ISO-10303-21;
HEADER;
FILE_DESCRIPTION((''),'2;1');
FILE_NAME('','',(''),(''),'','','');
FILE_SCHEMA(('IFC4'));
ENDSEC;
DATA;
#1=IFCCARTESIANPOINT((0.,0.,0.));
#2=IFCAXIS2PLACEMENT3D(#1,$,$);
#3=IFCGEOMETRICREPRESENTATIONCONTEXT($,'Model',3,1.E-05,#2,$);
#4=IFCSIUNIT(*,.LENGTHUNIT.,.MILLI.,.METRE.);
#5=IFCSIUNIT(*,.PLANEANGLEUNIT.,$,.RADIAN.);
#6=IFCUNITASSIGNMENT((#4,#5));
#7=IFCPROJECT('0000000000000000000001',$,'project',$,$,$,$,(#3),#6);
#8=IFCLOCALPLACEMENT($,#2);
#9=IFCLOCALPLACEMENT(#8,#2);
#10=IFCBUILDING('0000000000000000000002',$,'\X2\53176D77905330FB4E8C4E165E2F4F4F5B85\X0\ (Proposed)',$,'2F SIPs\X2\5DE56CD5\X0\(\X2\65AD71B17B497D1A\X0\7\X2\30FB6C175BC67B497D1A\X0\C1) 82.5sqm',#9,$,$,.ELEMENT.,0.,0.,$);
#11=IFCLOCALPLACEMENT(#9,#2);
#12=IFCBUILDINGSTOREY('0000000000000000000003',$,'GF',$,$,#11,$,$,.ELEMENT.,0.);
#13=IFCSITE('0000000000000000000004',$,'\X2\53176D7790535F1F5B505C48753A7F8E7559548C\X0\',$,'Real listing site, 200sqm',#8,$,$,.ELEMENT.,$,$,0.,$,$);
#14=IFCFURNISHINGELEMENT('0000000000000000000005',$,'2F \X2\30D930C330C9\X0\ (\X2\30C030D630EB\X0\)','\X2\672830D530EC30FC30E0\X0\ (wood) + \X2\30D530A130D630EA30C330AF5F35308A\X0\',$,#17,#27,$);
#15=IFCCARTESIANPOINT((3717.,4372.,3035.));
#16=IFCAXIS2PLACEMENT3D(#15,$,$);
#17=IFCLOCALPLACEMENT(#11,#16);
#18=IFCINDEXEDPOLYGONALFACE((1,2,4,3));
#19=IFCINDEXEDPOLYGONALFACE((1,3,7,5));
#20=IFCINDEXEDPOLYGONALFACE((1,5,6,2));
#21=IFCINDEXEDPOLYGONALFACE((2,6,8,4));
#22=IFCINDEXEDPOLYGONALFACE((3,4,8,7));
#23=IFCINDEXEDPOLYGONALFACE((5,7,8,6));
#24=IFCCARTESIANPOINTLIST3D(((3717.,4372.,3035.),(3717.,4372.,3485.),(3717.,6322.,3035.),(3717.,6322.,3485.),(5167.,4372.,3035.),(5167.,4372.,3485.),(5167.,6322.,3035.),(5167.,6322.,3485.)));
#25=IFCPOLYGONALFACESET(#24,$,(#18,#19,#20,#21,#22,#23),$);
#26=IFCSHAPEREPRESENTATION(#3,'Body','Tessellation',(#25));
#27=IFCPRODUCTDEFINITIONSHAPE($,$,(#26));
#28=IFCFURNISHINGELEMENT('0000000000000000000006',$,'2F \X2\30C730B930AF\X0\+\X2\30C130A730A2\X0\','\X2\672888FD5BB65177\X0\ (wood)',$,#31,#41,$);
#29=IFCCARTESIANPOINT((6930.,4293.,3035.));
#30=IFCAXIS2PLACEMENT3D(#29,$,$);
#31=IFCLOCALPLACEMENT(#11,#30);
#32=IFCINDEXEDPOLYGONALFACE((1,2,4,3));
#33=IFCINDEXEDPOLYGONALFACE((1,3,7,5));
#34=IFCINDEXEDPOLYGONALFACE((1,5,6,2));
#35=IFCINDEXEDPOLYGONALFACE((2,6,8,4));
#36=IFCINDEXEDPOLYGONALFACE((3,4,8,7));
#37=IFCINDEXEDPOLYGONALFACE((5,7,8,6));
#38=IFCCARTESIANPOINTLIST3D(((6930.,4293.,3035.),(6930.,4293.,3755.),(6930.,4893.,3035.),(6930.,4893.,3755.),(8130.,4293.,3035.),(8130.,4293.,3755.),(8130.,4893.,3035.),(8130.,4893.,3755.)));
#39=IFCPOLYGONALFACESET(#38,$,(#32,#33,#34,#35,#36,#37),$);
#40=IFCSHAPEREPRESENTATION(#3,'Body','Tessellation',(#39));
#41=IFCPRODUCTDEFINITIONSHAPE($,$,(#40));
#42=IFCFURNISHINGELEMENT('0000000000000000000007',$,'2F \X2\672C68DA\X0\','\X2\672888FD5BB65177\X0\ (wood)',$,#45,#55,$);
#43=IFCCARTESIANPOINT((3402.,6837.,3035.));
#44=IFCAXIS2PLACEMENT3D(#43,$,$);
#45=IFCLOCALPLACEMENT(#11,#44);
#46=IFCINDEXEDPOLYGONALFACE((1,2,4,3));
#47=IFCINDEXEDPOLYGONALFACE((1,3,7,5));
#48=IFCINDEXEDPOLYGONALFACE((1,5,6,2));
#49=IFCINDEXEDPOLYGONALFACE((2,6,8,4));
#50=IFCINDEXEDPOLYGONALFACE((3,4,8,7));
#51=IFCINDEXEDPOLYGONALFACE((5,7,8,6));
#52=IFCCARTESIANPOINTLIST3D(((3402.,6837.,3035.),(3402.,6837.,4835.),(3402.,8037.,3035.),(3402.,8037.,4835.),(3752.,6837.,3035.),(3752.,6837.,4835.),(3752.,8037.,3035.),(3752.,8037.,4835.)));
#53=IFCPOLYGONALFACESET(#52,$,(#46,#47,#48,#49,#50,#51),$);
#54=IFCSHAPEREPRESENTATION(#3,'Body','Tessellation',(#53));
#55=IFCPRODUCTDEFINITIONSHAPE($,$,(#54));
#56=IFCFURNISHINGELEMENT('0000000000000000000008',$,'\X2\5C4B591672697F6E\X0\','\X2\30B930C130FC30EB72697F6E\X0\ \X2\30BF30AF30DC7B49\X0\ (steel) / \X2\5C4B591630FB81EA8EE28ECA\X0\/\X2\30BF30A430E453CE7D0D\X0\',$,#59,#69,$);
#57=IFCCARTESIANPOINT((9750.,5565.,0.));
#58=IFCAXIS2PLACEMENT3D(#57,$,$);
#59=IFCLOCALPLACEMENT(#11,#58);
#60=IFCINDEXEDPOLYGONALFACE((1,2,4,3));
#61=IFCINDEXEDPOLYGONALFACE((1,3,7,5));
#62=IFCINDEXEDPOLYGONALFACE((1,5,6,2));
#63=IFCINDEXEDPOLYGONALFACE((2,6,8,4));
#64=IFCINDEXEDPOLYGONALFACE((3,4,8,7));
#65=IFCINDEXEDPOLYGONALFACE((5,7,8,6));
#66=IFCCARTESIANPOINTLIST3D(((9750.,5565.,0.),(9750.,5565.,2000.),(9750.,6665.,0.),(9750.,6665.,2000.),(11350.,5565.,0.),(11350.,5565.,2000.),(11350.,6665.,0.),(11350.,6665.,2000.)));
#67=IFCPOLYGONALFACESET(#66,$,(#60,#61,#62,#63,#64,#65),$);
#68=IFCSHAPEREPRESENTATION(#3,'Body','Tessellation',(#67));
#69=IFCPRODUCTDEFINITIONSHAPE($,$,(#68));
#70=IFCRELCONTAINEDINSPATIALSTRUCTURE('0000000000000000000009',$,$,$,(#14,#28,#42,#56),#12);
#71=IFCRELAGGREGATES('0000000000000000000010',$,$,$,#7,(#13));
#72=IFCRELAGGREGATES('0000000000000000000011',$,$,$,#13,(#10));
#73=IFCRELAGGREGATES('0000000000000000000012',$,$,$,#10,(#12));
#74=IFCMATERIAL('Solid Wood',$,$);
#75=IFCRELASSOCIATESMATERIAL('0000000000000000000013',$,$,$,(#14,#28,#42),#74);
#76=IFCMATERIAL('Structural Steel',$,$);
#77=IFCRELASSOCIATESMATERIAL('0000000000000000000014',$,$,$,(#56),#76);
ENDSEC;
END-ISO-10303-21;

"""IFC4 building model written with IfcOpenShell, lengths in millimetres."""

from ifc_helpers import new_model, si_unit, frame, frame_2d, origin, place, context, project, spatial, rectangle, extrude, material, element, save


model = new_model("IFC4")

# Units and contexts
model_context = context("Model", 3, precision=1e-05, world=origin())
ifc_project = project(units=[si_unit("LENGTHUNIT", "METRE", prefix="MILLI"), si_unit("PLANEANGLEUNIT", "RADIAN")], contexts=[model_context])

# Site, building, storey
site_placement = place(None, origin())
site = spatial("IfcSite", under=ifc_project, at=site_placement, Name="北海道弟子屈町美留和", ObjectType="Real listing site, 200sqm", CompositionType="ELEMENT", RefElevation=0.0)
building_placement = place(site_placement, origin())
building = spatial("IfcBuilding", under=site, at=building_placement, Name="北海道・二世帯住宅 (Proposed)", ObjectType="2F SIPs工法(断熱等級7・気密等級C1) 82.5sqm", CompositionType="ELEMENT", ElevationOfRefHeight=0.0, ElevationOfTerrain=0.0)
storey_placement = place(building_placement, origin())
storey = spatial("IfcBuildingStorey", under=building, at=storey_placement, Name="GF", CompositionType="ELEMENT", Elevation=0.0)

# Shared definitions
ifc_material_1 = material(Name="Solid Wood")

# Shared definitions
ifc_material_2 = material(Name="Structural Steel")

# Furnishing elements
furnishing_1_placement = place(storey_placement, frame((3717.0, 4372.0, 3035.0)))
element("IfcFurnishingElement", 1, at=furnishing_1_placement, inside=storey, material=ifc_material_1, Name="2F ベッド (ダブル)", Description="木フレーム (wood) + ファブリック張り", context=model_context, shape_type="SweptSolid", body=[
    extrude(rectangle(XDim=1450.0, YDim=1950.0, at=frame_2d((725.0, 975.0))), frame((3717.0, 4372.0, 3035.0)), (0.0, 0.0, 1.0), 450.0),
])
furnishing_2_placement = place(storey_placement, frame((6930.0, 4293.0, 3035.0)))
element("IfcFurnishingElement", 2, at=furnishing_2_placement, inside=storey, material=ifc_material_1, Name="2F デスク+チェア", Description="木製家具 (wood)", context=model_context, shape_type="SweptSolid", body=[
    extrude(rectangle(XDim=1200.0, YDim=600.0, at=frame_2d((600.0, 300.0))), frame((6930.0, 4293.0, 3035.0)), (0.0, 0.0, 1.0), 720.0),
])
furnishing_3_placement = place(storey_placement, frame((3402.0, 6837.0, 3035.0)))
element("IfcFurnishingElement", 3, at=furnishing_3_placement, inside=storey, material=ifc_material_1, Name="2F 本棚", Description="木製家具 (wood)", context=model_context, shape_type="SweptSolid", body=[
    extrude(rectangle(XDim=350.0, YDim=1200.0, at=frame_2d((175.0, 600.0))), frame((3402.0, 6837.0, 3035.0)), (0.0, 0.0, 1.0), 1800.0),
])
furnishing_4_placement = place(storey_placement, frame((9750.0, 5565.0, 0.0)))
element("IfcFurnishingElement", 4, at=furnishing_4_placement, inside=storey, material=ifc_material_2, Name="屋外物置", Description="スチール物置 タクボ等 (steel) / 屋外・自転車/タイヤ収納", context=model_context, shape_type="SweptSolid", body=[
    extrude(rectangle(XDim=1600.0, YDim=1100.0, at=frame_2d((800.0, 550.0))), frame((9750.0, 5565.0, 0.0)), (0.0, 0.0, 1.0), 2000.0),
])

save(model, "model.ifc")
